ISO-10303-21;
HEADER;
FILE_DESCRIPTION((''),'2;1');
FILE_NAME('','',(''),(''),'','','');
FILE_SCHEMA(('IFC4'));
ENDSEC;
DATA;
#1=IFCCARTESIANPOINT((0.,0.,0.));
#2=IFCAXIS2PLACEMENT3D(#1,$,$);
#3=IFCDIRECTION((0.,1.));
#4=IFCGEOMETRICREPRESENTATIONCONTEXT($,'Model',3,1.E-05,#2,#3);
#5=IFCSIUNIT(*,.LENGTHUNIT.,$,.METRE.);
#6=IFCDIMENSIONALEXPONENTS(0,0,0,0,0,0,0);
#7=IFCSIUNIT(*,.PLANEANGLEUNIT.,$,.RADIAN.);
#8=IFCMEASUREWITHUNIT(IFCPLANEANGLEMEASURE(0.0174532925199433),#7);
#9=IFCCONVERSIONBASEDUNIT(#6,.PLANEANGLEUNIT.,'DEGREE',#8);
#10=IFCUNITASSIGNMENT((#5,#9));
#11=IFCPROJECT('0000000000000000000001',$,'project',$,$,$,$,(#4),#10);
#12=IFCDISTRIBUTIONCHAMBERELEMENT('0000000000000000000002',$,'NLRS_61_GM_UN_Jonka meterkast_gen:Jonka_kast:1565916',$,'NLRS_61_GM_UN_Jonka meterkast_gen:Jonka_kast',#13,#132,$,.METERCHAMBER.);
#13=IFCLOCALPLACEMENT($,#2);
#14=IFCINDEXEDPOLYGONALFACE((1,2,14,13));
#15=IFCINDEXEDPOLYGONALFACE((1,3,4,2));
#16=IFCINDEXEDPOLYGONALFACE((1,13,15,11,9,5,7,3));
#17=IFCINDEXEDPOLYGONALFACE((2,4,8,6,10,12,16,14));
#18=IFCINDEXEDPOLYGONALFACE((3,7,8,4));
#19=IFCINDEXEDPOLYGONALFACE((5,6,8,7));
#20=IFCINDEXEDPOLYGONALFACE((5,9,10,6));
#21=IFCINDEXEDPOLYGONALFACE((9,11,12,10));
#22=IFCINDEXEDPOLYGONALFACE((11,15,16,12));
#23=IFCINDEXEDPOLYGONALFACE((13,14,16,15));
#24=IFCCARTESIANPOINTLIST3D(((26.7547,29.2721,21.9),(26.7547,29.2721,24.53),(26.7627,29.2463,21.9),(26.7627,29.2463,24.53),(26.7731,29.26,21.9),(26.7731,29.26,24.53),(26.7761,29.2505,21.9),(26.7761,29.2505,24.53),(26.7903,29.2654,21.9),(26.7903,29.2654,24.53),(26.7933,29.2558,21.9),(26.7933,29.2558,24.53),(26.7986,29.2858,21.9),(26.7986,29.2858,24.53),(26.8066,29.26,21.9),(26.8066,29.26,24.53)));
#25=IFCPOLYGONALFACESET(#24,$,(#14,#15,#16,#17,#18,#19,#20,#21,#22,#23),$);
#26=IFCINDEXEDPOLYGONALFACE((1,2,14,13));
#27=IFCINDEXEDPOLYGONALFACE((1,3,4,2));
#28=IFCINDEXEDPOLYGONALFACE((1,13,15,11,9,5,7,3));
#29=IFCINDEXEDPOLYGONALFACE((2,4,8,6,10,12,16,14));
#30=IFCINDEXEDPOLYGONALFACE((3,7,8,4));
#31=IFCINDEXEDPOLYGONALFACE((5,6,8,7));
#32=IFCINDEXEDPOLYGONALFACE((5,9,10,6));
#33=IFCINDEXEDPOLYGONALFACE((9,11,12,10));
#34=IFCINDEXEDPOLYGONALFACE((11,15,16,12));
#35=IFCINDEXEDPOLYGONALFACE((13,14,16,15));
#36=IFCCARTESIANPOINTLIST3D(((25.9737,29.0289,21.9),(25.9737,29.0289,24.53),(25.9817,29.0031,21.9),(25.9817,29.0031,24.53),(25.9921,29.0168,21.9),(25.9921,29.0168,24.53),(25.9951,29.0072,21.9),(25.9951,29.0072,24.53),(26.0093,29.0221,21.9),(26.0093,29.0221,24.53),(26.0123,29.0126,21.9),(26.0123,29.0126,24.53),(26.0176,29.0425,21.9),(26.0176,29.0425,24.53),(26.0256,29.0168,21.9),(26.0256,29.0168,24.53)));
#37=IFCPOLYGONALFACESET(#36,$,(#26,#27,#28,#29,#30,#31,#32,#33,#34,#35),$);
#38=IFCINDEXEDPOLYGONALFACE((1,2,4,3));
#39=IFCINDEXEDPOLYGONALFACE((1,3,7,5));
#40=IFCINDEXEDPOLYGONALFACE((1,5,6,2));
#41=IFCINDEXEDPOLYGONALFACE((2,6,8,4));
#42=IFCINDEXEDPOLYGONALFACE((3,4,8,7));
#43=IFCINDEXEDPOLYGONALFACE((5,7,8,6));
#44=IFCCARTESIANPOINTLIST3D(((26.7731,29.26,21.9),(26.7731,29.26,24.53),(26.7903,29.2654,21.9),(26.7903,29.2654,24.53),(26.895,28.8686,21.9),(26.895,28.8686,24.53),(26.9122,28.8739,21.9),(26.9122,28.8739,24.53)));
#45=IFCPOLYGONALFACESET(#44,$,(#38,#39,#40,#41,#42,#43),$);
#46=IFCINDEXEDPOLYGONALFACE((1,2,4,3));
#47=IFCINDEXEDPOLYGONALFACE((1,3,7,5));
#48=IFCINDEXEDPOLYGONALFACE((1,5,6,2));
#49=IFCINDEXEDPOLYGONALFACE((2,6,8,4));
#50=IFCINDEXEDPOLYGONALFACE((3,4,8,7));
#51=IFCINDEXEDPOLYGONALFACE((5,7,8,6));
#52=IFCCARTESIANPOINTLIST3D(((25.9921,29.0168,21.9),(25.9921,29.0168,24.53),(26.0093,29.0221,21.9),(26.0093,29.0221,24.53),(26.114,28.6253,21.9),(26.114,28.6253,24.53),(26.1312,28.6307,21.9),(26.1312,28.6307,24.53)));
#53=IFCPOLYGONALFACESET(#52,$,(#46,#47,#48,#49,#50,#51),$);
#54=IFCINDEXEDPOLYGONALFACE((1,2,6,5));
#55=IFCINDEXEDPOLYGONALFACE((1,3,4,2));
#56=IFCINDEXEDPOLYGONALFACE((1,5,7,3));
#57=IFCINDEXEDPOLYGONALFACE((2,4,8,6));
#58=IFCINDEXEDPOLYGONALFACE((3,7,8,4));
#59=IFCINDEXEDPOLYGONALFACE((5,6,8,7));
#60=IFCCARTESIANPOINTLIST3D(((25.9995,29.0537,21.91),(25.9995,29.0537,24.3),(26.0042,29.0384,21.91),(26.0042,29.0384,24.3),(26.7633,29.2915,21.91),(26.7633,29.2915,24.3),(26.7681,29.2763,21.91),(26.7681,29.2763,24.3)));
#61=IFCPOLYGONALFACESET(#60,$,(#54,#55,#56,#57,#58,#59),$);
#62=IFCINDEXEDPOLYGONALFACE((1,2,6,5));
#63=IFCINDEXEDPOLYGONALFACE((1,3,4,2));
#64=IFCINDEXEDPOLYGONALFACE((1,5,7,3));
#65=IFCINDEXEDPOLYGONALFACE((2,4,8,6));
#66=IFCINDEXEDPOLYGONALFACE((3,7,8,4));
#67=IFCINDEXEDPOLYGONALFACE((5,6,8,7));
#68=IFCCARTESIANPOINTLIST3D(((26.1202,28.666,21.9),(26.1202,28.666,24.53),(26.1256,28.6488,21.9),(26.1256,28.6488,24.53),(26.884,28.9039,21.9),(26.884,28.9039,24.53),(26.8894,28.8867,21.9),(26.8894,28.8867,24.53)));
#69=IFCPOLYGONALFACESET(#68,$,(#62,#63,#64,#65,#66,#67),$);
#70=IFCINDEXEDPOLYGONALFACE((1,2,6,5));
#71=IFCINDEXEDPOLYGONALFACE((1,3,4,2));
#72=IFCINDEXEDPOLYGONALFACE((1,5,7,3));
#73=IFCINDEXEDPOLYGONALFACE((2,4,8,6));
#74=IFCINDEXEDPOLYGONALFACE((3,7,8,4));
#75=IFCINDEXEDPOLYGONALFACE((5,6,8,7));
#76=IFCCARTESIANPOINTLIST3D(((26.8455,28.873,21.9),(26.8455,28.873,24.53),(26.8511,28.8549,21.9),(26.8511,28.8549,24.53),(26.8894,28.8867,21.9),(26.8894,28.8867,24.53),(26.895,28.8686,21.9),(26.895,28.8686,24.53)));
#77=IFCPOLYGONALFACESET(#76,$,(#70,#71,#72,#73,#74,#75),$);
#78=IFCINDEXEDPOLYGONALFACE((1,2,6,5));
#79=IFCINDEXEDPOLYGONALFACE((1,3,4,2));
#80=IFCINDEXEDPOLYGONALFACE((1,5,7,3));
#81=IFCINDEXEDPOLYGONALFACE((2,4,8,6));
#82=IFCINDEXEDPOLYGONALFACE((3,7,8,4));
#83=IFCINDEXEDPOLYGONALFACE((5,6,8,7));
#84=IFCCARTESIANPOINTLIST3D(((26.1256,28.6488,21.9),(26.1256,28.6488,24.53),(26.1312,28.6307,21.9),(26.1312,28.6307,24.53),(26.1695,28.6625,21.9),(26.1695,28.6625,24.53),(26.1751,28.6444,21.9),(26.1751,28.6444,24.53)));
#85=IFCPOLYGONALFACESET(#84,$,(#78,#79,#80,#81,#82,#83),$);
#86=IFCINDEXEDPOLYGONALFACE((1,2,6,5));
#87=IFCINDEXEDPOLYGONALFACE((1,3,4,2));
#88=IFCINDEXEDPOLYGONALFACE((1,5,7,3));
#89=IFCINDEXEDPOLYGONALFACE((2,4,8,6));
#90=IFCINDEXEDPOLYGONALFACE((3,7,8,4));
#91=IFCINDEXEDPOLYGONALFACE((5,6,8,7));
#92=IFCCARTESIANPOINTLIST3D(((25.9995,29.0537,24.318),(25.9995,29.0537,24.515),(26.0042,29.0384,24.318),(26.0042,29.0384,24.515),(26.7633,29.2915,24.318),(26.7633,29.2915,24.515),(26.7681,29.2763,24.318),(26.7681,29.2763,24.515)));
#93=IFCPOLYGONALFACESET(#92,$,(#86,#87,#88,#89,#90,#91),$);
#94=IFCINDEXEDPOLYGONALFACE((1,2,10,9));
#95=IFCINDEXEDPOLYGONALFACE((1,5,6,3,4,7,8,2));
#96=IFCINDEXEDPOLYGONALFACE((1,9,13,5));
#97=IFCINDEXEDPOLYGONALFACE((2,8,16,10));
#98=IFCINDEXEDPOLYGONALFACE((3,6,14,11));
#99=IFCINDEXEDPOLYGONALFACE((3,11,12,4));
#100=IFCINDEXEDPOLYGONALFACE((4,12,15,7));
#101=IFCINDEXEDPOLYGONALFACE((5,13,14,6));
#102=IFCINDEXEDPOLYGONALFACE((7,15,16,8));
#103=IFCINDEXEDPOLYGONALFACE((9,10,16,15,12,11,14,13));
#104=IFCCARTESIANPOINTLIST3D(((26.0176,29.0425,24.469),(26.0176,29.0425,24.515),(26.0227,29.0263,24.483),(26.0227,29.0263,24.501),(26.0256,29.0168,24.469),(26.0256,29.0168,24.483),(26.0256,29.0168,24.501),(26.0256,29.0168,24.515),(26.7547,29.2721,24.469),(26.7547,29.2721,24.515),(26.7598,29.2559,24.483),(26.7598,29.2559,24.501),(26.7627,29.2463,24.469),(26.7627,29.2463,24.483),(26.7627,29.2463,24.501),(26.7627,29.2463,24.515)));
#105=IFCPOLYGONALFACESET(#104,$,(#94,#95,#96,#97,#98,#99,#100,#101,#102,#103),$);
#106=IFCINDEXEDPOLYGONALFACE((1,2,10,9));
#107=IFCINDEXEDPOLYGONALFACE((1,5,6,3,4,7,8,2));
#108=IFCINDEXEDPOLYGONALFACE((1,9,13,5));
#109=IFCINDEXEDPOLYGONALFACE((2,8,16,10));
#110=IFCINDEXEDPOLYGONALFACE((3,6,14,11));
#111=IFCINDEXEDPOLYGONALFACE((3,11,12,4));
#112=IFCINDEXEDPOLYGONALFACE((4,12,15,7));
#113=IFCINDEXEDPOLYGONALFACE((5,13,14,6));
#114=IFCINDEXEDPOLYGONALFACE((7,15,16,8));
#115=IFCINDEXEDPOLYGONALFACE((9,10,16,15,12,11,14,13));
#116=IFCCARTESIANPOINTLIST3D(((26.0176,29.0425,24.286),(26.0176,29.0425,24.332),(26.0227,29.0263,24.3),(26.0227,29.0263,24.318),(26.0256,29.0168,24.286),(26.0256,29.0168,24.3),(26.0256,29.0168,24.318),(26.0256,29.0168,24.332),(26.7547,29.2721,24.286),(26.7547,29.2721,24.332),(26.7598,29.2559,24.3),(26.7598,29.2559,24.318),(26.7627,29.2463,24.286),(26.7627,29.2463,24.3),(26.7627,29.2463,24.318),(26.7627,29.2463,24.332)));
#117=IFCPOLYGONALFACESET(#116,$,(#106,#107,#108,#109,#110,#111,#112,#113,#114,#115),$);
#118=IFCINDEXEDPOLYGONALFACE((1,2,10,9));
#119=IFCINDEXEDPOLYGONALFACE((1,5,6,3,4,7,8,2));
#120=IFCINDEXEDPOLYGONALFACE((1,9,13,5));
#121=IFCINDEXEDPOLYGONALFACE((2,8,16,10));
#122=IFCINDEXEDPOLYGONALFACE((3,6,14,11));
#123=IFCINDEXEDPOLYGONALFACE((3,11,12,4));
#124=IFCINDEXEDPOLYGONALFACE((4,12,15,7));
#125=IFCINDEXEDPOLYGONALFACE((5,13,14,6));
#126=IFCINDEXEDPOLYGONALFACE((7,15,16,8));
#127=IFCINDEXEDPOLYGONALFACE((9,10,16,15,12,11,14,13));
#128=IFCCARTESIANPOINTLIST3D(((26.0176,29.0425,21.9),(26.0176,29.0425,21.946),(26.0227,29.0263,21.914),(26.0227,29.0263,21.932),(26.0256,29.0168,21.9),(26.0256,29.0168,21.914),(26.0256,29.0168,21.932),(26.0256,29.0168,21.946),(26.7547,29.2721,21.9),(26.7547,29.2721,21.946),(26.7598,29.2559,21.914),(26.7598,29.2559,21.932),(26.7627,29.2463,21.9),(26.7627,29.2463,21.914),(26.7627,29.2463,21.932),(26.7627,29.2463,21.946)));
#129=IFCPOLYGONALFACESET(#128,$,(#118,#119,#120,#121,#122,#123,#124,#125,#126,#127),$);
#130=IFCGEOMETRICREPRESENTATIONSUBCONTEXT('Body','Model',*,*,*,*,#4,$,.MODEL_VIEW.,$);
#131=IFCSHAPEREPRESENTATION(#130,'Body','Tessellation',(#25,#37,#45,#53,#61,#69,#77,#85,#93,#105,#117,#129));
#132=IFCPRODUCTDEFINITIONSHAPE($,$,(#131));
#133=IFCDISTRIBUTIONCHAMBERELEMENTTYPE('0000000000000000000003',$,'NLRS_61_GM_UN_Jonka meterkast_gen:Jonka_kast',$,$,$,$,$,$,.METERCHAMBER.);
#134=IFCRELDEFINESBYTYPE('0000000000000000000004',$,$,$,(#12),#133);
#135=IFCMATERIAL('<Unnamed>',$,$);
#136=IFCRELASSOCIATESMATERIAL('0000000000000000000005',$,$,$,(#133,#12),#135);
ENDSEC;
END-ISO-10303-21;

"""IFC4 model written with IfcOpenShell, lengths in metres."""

from ifc_helpers import new_model, entity, si_unit, converted_unit, direction, frame, origin, place, context, subcontext, project, indexed_curve, outline, extrude, source, transform, mapped, material, type_object, type_shapes, element, save


model = new_model("IFC4")

# Units and contexts
model_context = context("Model", 3, precision=1e-05, world=origin(), true_north=direction((0.0, 1.0)))
body_context = subcontext(model_context, "Body", "Model", "MODEL_VIEW")
ifc_project = project(units=[si_unit("LENGTHUNIT", "METRE"), converted_unit("PLANEANGLEUNIT", "DEGREE", entity("IfcPlaneAngleMeasure", 0.0174532925199433), si_unit("PLANEANGLEUNIT", "RADIAN"), dimensions=[0, 0, 0, 0, 0, 0, 0])], contexts=[model_context])

# Distribution chamber element
ifc_material = material(Name="<Unnamed>")
distribution_chamber_element_type = type_object("IfcDistributionChamberElementType", Name="NLRS_61_GM_UN_Jonka meterkast_gen:Jonka_kast", PredefinedType="METERCHAMBER", material=ifc_material)
shared_shape_1 = source(origin(), body_context, "Body", "SweptSolid", [
    extrude(outline(indexed_curve([(-0.0093, -0.023), (0.0178, -0.023), (0.0178, 0.023), (-0.0093, 0.023), (-0.0093, 0.009), (0.0007, 0.009), (0.0007, -0.009), (-0.0093, -0.009), (-0.0093, -0.023)], self_intersect=False)), frame((-0.409, -0.4092, 0.0), z_axis=(0.0, 0.0, 1.0), x_axis=(0.0, -1.0, 0.0)), (0.0, 0.0, 1.0), 2.63),
    extrude(outline(indexed_curve([(-0.0093, -0.023), (0.0178, -0.023), (0.0178, 0.023), (-0.0093, 0.023), (-0.0093, 0.009), (0.0007, 0.009), (0.0007, -0.009), (-0.0093, -0.009), (-0.0093, -0.023)], self_intersect=False)), frame((0.409, -0.4092, 0.0), z_axis=(0.0, 0.0, 1.0), x_axis=(0.0, -1.0, 0.0)), (0.0, 0.0, 1.0), 2.63),
    extrude(outline(indexed_curve([(-0.205, -0.009), (0.205, -0.009), (0.205, 0.009), (-0.205, 0.009), (-0.205, -0.009)], self_intersect=False)), frame((-0.409, -0.205, 0.0), z_axis=(0.0, 0.0, 1.0), x_axis=(0.0, -1.0, 0.0)), (0.0, 0.0, 1.0), 2.63),
    extrude(outline(indexed_curve([(-0.205, -0.009), (0.205, -0.009), (0.205, 0.009), (-0.205, 0.009), (-0.205, -0.009)], self_intersect=False)), frame((0.409, -0.205, 0.0), z_axis=(0.0, 0.0, 1.0), x_axis=(0.0, -1.0, 0.0)), (0.0, 0.0, 1.0), 2.63),
    extrude(outline(indexed_curve([(-0.4, -0.008), (0.4, -0.008), (0.4, 0.008), (-0.4, 0.008), (-0.4, -0.008)], self_intersect=False)), frame((0.0, -0.435, 0.01), z_axis=(0.0, 0.0, 1.0), x_axis=(-1.0, 0.0, 0.0)), (0.0, 0.0, 1.0), 2.39),
    extrude(outline(indexed_curve([(-0.4, -0.009), (0.4, -0.009), (0.4, 0.009), (-0.4, 0.009), (-0.4, -0.009)], self_intersect=False)), frame((0.0, -0.028, 0.0), z_axis=(0.0, 0.0, 1.0), x_axis=(-1.0, 0.0, 0.0)), (0.0, 0.0, 1.0), 2.63),
    extrude(outline(indexed_curve([(-0.023, -0.0095), (0.023, -0.0095), (0.023, 0.0095), (-0.023, 0.0095), (-0.023, -0.0095)], self_intersect=False)), frame((-0.377, -0.0095, 0.0), z_axis=(0.0, 0.0, 1.0), x_axis=(-1.0, 0.0, 0.0)), (0.0, 0.0, 1.0), 2.63),
    extrude(outline(indexed_curve([(-0.023, -0.0095), (0.023, -0.0095), (0.023, 0.0095), (-0.023, 0.0095), (-0.023, -0.0095)], self_intersect=False)), frame((0.377, -0.0095, 0.0), z_axis=(0.0, 0.0, 1.0), x_axis=(-1.0, 0.0, 0.0)), (0.0, 0.0, 1.0), 2.63),
    extrude(outline(indexed_curve([(-0.4, -0.008), (0.4, -0.008), (0.4, 0.008), (-0.4, 0.008), (-0.4, -0.008)], self_intersect=False)), frame((0.0, -0.435, 2.418), z_axis=(0.0, 0.0, 1.0), x_axis=(-1.0, 0.0, 0.0)), (0.0, 0.0, 1.0), 0.197),
    extrude(outline(indexed_curve([(-0.023, -0.0178), (0.023, -0.0178), (0.023, 0.0093), (0.009, 0.0093), (0.009, -0.0007), (-0.009, -0.0007), (-0.009, 0.0093), (-0.023, 0.0093), (-0.023, -0.0178)], self_intersect=False)), frame((-0.386, -0.4092, 2.592), z_axis=(1.0, 0.0, 0.0), x_axis=(0.0, 0.0, -1.0)), (0.0, 0.0, 1.0), 0.772),
    extrude(outline(indexed_curve([(-0.023, -0.0178), (0.023, -0.0178), (0.023, 0.0093), (0.009, 0.0093), (0.009, -0.0007), (-0.009, -0.0007), (-0.009, 0.0093), (-0.023, 0.0093), (-0.023, -0.0178)], self_intersect=False)), frame((-0.386, -0.4092, 2.409), z_axis=(1.0, 0.0, 0.0), x_axis=(0.0, 0.0, -1.0)), (0.0, 0.0, 1.0), 0.772),
    extrude(outline(indexed_curve([(-0.023, -0.0178), (0.023, -0.0178), (0.023, 0.0093), (0.009, 0.0093), (0.009, -0.0007), (-0.009, -0.0007), (-0.009, 0.0093), (-0.023, 0.0093), (-0.023, -0.0178)], self_intersect=False)), frame((-0.386, -0.4092, 0.023), z_axis=(1.0, 0.0, 0.0), x_axis=(0.0, 0.0, -1.0)), (0.0, 0.0, 1.0), 0.772),
])
type_shapes(distribution_chamber_element_type, [shared_shape_1])
placement_1 = place(None, frame((13.1348, 11.9886, 0.0), z_axis=(0.0, 0.0, 1.0), x_axis=(0.954771, 0.297342, 0.0)))
placement_2 = place(placement_1, origin())
placement_3 = place(placement_2, frame((0.0, 0.0, 21.9)))
placement_4 = place(placement_3, origin())
distribution_chamber_element_1_placement = place(placement_4, frame((17.757, 12.025, 0.0), z_axis=(0.0, 0.0, 1.0), x_axis=(-1.0, 0.0, 0.0)))
element("IfcDistributionChamberElement", 1, at=distribution_chamber_element_1_placement, type_object=distribution_chamber_element_type, material=ifc_material, Name="NLRS_61_GM_UN_Jonka meterkast_gen:Jonka_kast:1565916", ObjectType="NLRS_61_GM_UN_Jonka meterkast_gen:Jonka_kast", PredefinedType="METERCHAMBER", context=body_context, shape_type="MappedRepresentation", body=[
    mapped(shared_shape_1, transform((0.0, 0.0, 0.0), scale=1.0)),
])

save(model, "model.ifc")
